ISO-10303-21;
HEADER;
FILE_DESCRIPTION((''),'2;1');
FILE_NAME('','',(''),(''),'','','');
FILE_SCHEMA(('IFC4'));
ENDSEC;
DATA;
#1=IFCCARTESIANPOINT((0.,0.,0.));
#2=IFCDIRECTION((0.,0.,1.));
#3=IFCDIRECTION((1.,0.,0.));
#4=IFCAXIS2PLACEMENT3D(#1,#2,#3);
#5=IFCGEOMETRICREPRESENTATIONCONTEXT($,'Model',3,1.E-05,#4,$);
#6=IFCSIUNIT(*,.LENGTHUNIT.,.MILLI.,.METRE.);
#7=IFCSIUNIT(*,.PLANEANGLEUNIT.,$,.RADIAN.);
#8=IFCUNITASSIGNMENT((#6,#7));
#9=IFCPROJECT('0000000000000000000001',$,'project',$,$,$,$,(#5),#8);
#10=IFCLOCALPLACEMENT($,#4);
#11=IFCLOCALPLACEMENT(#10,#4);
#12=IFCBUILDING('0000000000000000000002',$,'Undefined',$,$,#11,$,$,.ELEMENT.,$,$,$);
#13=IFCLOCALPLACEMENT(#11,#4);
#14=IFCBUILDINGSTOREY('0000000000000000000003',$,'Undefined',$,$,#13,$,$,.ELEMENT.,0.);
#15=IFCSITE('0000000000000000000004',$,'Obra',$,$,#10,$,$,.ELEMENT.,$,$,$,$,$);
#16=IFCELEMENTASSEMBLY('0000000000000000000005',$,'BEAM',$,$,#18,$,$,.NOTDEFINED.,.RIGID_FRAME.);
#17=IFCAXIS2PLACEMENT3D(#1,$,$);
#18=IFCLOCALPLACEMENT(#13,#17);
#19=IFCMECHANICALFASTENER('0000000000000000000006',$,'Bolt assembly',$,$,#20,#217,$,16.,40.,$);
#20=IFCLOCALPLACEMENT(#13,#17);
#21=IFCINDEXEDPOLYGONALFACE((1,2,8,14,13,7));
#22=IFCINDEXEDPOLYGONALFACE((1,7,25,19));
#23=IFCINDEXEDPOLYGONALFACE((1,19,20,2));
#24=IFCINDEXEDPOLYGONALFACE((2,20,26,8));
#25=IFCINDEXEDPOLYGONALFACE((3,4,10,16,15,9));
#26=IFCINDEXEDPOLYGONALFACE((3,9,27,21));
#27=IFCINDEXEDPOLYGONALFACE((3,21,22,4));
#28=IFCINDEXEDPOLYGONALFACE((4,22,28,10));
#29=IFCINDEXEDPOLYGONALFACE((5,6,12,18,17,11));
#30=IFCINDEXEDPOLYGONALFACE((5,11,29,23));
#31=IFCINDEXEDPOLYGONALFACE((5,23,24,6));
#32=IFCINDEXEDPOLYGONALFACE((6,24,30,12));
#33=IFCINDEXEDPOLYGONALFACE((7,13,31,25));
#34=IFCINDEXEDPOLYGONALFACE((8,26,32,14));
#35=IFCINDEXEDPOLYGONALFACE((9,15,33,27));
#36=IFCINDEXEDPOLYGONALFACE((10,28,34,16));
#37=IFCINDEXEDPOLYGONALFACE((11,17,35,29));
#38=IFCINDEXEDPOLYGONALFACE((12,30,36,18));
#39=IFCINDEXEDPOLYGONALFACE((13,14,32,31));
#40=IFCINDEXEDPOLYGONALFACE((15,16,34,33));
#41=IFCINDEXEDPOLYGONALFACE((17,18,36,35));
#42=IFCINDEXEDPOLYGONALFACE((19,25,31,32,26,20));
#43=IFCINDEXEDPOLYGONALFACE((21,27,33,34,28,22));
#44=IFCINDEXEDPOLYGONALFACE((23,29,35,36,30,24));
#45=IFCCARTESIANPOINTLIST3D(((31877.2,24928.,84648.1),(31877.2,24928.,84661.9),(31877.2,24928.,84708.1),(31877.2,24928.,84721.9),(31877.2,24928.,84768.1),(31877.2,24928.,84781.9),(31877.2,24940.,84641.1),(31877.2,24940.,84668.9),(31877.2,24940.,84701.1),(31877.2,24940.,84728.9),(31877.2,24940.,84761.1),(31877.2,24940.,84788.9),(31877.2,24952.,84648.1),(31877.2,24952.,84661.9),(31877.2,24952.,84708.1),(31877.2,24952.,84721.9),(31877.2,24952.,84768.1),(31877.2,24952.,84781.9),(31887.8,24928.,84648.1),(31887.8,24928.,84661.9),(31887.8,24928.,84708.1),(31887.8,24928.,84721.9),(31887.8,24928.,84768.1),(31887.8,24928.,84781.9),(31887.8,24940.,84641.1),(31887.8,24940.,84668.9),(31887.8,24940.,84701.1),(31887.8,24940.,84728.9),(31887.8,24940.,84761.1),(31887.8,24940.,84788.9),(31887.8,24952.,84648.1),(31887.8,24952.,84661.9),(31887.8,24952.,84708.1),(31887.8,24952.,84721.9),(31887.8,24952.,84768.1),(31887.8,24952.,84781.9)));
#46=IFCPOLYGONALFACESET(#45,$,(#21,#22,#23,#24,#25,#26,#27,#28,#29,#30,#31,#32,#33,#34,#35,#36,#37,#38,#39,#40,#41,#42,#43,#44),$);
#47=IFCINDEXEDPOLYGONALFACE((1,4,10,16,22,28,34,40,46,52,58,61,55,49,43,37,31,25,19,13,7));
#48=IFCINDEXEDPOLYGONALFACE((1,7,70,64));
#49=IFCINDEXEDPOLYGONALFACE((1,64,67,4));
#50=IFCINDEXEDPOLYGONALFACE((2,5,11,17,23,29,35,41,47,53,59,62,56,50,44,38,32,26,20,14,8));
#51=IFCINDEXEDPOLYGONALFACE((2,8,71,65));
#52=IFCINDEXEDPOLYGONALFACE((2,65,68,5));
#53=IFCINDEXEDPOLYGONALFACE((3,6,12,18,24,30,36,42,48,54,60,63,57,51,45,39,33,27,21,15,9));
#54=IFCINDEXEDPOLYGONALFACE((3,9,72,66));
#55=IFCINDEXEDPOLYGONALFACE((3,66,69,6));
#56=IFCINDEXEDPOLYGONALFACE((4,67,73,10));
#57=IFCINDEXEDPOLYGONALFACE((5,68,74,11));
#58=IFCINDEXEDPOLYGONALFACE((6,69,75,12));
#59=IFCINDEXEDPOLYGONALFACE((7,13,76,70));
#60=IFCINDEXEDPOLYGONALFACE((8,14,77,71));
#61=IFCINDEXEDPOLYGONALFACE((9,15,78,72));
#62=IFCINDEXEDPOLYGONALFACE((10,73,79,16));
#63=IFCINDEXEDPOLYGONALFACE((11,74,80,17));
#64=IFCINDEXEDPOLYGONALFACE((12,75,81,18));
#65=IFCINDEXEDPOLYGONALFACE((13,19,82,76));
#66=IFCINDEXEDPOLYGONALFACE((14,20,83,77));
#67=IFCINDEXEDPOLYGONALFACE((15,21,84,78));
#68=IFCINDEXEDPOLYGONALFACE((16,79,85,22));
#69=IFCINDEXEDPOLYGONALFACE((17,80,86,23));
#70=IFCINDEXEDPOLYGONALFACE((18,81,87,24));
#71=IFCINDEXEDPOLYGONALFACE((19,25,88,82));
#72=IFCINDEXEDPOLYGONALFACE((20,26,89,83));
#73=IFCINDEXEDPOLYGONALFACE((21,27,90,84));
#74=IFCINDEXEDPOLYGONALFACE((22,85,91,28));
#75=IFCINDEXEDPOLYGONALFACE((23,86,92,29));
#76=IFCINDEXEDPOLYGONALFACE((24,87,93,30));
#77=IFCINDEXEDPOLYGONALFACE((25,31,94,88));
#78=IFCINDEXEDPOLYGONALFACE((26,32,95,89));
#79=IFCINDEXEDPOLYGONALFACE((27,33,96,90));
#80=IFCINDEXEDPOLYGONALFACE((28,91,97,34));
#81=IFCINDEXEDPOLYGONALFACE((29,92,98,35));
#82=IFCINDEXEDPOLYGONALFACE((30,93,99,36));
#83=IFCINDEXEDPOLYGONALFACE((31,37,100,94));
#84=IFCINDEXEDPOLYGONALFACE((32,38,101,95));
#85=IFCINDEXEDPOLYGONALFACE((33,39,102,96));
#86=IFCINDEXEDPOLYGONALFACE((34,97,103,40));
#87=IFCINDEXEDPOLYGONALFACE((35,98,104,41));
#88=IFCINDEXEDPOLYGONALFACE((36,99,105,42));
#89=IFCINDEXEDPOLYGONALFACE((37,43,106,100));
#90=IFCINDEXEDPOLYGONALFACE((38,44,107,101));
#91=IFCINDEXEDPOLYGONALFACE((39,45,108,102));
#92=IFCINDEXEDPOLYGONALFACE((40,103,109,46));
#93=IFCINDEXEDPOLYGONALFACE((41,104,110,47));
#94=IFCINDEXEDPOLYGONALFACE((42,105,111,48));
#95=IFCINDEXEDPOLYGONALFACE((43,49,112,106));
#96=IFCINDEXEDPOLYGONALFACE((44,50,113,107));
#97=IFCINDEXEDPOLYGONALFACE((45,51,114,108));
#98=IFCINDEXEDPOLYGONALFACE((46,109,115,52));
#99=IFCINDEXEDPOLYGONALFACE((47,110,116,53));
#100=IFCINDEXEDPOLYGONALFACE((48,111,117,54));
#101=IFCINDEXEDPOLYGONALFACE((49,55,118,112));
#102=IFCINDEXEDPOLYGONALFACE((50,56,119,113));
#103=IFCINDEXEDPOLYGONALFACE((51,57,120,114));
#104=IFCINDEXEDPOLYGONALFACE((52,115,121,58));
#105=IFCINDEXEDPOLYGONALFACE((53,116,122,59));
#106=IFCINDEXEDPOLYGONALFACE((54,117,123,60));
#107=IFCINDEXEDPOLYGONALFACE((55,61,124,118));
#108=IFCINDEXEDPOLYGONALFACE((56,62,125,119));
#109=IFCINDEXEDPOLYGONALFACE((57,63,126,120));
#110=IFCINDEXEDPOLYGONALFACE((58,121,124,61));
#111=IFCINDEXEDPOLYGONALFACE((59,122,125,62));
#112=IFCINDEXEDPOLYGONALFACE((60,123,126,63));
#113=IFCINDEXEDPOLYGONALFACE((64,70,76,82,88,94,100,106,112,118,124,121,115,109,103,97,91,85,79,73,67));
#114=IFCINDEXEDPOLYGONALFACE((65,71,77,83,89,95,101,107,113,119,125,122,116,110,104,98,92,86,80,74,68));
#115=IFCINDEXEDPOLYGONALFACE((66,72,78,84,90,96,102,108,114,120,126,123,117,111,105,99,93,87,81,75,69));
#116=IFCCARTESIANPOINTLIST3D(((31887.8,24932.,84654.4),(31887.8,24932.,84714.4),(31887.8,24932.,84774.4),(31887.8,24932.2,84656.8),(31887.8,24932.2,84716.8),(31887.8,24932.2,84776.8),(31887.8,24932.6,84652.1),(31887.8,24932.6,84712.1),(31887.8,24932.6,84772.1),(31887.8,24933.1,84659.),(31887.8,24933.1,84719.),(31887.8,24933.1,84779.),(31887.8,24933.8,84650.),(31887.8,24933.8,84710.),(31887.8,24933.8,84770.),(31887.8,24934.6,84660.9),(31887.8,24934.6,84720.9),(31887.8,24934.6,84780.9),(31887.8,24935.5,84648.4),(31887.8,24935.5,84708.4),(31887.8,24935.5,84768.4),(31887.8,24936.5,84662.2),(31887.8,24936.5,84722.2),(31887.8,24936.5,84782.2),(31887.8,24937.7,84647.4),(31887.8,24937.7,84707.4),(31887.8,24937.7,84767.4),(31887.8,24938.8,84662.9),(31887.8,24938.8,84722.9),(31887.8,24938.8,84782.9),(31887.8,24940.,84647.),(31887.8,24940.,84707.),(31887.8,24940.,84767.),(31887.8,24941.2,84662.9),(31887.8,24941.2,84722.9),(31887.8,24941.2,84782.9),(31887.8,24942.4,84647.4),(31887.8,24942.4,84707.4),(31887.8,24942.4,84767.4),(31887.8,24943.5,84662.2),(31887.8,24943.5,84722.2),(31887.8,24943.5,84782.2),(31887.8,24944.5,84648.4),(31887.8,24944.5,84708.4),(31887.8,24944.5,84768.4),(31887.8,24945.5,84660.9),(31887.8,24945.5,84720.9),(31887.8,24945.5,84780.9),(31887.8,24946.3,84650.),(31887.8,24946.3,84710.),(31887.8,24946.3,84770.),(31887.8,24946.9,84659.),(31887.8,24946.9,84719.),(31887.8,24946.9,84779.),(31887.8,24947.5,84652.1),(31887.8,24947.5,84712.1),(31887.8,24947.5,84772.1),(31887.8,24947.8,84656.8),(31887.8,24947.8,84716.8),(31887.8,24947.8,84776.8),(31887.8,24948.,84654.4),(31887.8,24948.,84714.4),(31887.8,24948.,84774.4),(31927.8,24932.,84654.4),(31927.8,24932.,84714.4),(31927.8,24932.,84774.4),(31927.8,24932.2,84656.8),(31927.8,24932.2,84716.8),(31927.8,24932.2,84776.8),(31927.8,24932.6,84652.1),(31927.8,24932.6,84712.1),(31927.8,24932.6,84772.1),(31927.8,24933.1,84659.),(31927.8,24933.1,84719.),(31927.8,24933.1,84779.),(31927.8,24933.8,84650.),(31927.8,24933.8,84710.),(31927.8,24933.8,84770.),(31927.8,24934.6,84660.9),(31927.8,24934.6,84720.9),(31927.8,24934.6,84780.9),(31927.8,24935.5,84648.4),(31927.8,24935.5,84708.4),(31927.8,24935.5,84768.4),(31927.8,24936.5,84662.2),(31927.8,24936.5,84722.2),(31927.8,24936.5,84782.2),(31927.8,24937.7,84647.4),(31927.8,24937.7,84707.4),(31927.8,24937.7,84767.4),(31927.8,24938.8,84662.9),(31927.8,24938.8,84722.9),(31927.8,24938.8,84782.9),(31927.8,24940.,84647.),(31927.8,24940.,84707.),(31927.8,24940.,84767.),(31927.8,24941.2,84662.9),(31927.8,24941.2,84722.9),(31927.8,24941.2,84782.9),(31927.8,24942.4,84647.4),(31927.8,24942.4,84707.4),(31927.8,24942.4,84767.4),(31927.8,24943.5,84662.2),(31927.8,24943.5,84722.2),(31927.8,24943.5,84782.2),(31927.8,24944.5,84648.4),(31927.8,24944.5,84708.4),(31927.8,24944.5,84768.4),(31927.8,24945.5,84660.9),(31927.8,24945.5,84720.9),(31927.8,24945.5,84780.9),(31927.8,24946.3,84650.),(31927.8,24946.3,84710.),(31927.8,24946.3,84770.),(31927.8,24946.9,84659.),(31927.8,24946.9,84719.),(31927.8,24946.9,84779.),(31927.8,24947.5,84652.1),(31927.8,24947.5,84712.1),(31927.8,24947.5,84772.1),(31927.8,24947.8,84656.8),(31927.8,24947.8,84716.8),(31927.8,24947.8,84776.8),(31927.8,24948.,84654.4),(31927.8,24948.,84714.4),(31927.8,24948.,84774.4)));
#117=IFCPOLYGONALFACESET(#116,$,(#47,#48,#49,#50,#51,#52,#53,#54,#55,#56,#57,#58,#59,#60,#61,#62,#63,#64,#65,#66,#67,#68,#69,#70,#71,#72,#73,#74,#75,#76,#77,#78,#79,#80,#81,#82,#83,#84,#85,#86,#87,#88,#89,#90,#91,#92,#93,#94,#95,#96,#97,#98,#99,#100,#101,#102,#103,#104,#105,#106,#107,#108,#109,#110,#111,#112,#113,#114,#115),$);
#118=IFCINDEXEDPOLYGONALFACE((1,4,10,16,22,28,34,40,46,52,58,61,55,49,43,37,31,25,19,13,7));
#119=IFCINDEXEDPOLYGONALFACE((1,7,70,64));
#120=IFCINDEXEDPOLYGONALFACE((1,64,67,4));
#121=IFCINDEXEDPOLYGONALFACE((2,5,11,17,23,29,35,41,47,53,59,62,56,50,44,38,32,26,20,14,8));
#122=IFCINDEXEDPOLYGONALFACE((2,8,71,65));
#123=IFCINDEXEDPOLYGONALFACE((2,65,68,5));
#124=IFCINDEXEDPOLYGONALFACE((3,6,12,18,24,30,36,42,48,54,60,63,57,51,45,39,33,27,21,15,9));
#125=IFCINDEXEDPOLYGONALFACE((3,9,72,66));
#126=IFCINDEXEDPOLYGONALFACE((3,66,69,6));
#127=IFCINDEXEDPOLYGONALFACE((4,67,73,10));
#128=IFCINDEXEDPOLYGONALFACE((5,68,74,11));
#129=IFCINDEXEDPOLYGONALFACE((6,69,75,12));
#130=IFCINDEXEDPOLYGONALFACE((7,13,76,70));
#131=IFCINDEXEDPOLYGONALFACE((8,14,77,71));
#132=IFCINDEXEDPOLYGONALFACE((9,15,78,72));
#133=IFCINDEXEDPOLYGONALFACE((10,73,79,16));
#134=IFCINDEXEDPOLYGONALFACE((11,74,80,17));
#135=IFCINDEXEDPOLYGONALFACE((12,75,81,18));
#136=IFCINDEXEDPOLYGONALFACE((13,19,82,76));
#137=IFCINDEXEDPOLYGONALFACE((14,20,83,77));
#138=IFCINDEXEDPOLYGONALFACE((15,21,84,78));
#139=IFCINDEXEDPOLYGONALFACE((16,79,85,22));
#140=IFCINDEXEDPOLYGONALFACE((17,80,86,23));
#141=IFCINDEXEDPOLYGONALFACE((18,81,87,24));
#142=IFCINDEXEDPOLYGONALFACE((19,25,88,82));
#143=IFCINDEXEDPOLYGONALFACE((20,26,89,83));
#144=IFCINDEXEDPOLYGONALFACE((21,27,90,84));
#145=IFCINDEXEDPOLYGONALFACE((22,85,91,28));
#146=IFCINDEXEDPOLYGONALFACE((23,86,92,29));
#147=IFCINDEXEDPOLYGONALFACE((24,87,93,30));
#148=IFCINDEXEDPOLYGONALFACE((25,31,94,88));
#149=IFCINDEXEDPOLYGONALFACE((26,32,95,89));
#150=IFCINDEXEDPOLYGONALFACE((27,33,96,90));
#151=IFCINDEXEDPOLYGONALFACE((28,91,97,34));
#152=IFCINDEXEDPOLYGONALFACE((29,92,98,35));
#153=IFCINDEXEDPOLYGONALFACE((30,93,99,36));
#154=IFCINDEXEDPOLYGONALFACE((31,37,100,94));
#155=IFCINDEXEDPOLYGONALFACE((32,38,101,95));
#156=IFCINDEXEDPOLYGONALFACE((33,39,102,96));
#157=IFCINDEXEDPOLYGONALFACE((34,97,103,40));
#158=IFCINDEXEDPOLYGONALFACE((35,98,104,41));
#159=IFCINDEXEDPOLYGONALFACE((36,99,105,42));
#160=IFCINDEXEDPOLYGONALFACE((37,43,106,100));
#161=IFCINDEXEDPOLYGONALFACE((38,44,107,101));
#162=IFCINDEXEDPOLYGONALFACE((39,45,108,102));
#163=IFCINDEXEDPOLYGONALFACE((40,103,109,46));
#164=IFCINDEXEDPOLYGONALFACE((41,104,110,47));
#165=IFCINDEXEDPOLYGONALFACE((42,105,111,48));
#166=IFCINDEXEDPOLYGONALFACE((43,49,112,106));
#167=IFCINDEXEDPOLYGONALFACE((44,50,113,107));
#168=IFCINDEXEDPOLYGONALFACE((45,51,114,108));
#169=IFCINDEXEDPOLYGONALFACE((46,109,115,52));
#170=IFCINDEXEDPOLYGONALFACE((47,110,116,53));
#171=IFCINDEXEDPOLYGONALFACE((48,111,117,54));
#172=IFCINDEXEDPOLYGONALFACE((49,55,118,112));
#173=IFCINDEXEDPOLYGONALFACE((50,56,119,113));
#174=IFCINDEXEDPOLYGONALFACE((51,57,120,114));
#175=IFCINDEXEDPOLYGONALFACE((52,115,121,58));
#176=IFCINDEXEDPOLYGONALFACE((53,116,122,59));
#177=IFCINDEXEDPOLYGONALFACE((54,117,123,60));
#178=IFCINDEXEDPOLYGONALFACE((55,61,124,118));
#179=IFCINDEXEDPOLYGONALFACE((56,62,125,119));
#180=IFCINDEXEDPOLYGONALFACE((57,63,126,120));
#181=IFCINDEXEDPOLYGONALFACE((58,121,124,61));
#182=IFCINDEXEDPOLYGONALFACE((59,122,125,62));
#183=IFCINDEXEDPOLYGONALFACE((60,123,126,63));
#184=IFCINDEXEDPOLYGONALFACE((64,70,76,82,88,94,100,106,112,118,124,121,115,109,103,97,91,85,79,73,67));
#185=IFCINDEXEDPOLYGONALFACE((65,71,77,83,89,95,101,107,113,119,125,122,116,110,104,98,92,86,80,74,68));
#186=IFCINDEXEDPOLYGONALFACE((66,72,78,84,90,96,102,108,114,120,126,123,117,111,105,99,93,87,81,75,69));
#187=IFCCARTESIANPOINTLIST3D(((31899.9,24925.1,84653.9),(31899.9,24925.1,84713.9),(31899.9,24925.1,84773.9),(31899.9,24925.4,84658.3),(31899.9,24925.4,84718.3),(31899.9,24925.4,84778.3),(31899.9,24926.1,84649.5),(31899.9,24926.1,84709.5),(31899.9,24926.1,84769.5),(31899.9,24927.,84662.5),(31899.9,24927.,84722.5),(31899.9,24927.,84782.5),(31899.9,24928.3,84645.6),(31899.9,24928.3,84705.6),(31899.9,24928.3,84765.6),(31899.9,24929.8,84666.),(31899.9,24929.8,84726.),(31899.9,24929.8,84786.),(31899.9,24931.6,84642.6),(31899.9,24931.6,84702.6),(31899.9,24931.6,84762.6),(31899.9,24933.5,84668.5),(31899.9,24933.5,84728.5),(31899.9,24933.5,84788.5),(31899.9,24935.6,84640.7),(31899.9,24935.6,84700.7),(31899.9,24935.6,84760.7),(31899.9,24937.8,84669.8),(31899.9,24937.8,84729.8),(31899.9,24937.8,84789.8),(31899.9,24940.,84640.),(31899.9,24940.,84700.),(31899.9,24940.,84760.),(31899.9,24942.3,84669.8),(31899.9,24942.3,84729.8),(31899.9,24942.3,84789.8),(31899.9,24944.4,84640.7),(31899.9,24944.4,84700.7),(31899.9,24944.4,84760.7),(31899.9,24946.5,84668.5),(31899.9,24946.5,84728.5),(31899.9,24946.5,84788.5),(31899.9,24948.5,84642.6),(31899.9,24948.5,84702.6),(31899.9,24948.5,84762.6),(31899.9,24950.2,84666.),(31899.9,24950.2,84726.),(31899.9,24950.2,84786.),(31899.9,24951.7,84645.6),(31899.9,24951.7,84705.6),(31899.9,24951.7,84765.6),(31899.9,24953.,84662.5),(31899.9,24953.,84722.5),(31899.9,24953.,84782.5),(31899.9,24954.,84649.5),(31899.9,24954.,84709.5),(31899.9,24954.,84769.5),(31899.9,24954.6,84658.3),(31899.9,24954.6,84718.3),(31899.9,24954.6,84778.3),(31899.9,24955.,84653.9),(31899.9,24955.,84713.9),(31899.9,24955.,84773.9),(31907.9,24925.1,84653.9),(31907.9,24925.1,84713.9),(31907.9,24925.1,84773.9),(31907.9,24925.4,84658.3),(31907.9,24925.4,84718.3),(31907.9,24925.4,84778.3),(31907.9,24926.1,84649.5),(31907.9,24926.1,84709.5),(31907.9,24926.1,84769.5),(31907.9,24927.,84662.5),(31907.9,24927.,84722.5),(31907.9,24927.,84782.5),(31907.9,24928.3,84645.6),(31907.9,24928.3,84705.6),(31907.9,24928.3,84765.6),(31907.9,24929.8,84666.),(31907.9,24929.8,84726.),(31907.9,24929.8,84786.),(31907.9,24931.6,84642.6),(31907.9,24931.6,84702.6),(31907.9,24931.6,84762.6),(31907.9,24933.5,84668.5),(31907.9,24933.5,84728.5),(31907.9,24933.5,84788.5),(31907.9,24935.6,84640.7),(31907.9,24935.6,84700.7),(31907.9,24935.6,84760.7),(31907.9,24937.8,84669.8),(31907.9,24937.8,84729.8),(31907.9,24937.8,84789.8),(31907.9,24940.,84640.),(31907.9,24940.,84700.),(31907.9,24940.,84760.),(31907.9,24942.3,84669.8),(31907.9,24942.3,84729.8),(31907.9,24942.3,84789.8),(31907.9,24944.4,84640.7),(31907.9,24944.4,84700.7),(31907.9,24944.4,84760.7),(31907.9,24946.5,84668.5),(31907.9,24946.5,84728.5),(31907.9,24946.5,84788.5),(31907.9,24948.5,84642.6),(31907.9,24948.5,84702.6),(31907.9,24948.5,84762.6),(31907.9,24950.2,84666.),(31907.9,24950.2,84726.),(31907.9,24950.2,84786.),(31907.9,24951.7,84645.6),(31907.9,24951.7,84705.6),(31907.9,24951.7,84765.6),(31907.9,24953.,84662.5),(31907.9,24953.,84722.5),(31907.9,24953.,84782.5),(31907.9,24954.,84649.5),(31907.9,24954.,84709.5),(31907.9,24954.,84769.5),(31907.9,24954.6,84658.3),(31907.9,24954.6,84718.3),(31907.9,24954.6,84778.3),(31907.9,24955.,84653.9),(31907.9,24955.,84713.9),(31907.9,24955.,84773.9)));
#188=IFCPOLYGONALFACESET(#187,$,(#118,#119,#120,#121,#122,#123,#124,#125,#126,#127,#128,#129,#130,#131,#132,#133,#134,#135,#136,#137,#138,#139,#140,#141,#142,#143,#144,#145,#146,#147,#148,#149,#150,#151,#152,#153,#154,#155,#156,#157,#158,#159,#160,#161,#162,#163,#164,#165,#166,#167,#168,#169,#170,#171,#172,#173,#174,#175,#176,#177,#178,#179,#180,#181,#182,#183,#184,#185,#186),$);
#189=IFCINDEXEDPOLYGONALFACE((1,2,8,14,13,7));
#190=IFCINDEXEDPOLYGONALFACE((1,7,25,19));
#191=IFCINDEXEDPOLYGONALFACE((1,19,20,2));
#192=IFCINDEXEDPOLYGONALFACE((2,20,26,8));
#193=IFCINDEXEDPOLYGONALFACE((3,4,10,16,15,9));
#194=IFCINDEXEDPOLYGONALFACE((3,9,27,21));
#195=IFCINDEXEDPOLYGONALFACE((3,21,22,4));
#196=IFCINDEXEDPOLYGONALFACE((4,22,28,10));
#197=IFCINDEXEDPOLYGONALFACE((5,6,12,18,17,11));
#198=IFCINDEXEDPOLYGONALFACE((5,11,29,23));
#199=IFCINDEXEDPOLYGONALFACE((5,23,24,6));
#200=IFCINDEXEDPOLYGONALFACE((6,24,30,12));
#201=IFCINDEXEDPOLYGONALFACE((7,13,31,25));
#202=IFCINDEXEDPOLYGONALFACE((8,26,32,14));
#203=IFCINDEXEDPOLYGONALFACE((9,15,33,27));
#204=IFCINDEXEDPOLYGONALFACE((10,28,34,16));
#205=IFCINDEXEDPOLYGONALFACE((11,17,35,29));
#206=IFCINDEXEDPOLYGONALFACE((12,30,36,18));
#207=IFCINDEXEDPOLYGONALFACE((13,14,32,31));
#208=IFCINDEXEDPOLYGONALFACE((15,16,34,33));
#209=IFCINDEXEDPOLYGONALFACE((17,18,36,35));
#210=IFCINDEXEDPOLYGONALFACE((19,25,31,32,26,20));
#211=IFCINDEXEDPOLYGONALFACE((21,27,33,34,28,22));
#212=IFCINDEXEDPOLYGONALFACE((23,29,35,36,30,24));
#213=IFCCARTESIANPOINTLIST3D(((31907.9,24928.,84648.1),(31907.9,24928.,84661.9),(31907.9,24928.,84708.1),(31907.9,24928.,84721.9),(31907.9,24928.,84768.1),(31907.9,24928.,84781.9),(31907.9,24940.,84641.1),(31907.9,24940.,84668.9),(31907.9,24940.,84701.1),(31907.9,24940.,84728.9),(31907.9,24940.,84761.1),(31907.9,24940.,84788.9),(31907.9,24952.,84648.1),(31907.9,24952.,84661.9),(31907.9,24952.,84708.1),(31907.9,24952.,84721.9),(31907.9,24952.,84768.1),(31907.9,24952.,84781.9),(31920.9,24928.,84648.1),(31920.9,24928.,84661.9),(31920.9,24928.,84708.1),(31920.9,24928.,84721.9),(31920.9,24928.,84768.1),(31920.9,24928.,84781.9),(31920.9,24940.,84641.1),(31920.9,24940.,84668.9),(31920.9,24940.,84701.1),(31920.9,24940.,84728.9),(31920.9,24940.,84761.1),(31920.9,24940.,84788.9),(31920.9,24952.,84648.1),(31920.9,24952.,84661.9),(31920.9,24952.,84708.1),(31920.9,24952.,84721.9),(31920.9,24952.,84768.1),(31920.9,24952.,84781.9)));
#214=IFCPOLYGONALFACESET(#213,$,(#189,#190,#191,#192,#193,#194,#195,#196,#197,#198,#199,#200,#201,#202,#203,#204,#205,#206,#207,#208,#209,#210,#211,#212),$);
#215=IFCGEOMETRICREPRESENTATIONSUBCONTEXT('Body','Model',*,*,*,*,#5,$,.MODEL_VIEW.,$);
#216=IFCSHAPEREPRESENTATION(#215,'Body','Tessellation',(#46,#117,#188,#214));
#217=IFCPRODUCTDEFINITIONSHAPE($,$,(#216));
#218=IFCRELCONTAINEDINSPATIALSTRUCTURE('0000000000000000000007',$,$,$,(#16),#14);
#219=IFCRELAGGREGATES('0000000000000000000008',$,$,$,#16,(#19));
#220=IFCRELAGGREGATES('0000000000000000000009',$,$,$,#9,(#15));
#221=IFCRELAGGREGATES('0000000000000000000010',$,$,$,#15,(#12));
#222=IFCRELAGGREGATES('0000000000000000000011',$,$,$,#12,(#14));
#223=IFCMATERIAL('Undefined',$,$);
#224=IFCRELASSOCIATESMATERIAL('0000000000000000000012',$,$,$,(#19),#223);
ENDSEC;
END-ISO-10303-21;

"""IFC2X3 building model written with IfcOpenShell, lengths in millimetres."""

from ifc_helpers import new_model, si_unit, frame, origin_with_axes, origin_2d_with_axis, place, context, subcontext, project, spatial, polyline, circle, outline, extrude, source, transform, mapped, material, element, aggregate, save


model = new_model("IFC2X3")

# Units and contexts
model_context = context("Model", 3, precision=1e-05, world=origin_with_axes())
body_context = subcontext(model_context, "Body", "Model", "MODEL_VIEW")
ifc_project = project(units=[si_unit("LENGTHUNIT", "METRE", prefix="MILLI"), si_unit("PLANEANGLEUNIT", "RADIAN")], contexts=[model_context])

# Site, building, storey
site_placement = place(None, origin_with_axes())
site = spatial("IfcSite", under=ifc_project, at=site_placement, Name="Obra", CompositionType="ELEMENT")
building_placement = place(site_placement, origin_with_axes())
building = spatial("IfcBuilding", under=site, at=building_placement, Name="Undefined", CompositionType="ELEMENT")
storey_placement = place(building_placement, origin_with_axes())
storey = spatial("IfcBuildingStorey", under=building, at=storey_placement, Name="Undefined", CompositionType="ELEMENT", Elevation=0.0)

# Shared definitions
ifc_material_1 = material(Name="Undefined")

# Element assembly
assembly_1_placement = place(storey_placement, origin_with_axes())
assembly_1 = element("IfcElementAssembly", 1, at=assembly_1_placement, inside=storey, Name="BEAM", AssemblyPlace="NOTDEFINED", PredefinedType="RIGID_FRAME")

# Mechanical fastener
shared_shape_1 = source(origin_with_axes(), body_context, "Body", "SweptSolid", [
    extrude(outline(polyline([(13.9, 0.0), (6.9, 12.0), (-6.9, 12.0), (-13.9, 0.0), (-6.9, -12.0), (6.9, -12.0), (13.9, 0.0)])), frame((0.0, -19.7, 0.0), z_axis=(0.0, 1.0, 0.0), x_axis=(1.0, 0.0, 0.0)), (0.0, 0.0, 1.0), 10.6),
    extrude(circle(Radius=8.0, at=origin_2d_with_axis()), frame((0.0, -9.1, 0.0), z_axis=(0.0, 1.0, 0.0), x_axis=(1.0, 0.0, 0.0)), (0.0, 0.0, 1.0), 40.0),
    extrude(circle(Radius=15.0, at=origin_2d_with_axis()), frame((0.0, 3.0, 0.0), z_axis=(0.0, 1.0, 0.0), x_axis=(1.0, 0.0, 0.0)), (0.0, 0.0, 1.0), 8.0),
    extrude(outline(polyline([(13.9, 0.0), (6.9, 12.0), (-6.9, 12.0), (-13.9, 0.0), (-6.9, -12.0), (6.9, -12.0), (13.9, 0.0)])), frame((0.0, 11.0, 0.0), z_axis=(0.0, 1.0, 0.0), x_axis=(1.0, 0.0, 0.0)), (0.0, 0.0, 1.0), 13.0),
])
mechanical_fastener_1_placement = place(assembly_1_placement, frame((31896.9, 24990.0, 84835.0), z_axis=(0.000002, -1.0, 0.0), x_axis=(0.0, 0.0, -1.0)))
mechanical_fastener_1 = element("IfcMechanicalFastener", 2, at=mechanical_fastener_1_placement, material=ifc_material_1, Name="Bolt assembly", NominalDiameter=16.0, NominalLength=40.0, context=body_context, shape_type="MappedRepresentation", body=[
    mapped(shared_shape_1, transform((60.0, 0.0, 50.0))),
    mapped(shared_shape_1, transform((120.0, 0.0, 50.0))),
    mapped(shared_shape_1, transform((180.0, 0.0, 50.0))),
])
aggregate(assembly_1, [mechanical_fastener_1])

save(model, "model.ifc")
